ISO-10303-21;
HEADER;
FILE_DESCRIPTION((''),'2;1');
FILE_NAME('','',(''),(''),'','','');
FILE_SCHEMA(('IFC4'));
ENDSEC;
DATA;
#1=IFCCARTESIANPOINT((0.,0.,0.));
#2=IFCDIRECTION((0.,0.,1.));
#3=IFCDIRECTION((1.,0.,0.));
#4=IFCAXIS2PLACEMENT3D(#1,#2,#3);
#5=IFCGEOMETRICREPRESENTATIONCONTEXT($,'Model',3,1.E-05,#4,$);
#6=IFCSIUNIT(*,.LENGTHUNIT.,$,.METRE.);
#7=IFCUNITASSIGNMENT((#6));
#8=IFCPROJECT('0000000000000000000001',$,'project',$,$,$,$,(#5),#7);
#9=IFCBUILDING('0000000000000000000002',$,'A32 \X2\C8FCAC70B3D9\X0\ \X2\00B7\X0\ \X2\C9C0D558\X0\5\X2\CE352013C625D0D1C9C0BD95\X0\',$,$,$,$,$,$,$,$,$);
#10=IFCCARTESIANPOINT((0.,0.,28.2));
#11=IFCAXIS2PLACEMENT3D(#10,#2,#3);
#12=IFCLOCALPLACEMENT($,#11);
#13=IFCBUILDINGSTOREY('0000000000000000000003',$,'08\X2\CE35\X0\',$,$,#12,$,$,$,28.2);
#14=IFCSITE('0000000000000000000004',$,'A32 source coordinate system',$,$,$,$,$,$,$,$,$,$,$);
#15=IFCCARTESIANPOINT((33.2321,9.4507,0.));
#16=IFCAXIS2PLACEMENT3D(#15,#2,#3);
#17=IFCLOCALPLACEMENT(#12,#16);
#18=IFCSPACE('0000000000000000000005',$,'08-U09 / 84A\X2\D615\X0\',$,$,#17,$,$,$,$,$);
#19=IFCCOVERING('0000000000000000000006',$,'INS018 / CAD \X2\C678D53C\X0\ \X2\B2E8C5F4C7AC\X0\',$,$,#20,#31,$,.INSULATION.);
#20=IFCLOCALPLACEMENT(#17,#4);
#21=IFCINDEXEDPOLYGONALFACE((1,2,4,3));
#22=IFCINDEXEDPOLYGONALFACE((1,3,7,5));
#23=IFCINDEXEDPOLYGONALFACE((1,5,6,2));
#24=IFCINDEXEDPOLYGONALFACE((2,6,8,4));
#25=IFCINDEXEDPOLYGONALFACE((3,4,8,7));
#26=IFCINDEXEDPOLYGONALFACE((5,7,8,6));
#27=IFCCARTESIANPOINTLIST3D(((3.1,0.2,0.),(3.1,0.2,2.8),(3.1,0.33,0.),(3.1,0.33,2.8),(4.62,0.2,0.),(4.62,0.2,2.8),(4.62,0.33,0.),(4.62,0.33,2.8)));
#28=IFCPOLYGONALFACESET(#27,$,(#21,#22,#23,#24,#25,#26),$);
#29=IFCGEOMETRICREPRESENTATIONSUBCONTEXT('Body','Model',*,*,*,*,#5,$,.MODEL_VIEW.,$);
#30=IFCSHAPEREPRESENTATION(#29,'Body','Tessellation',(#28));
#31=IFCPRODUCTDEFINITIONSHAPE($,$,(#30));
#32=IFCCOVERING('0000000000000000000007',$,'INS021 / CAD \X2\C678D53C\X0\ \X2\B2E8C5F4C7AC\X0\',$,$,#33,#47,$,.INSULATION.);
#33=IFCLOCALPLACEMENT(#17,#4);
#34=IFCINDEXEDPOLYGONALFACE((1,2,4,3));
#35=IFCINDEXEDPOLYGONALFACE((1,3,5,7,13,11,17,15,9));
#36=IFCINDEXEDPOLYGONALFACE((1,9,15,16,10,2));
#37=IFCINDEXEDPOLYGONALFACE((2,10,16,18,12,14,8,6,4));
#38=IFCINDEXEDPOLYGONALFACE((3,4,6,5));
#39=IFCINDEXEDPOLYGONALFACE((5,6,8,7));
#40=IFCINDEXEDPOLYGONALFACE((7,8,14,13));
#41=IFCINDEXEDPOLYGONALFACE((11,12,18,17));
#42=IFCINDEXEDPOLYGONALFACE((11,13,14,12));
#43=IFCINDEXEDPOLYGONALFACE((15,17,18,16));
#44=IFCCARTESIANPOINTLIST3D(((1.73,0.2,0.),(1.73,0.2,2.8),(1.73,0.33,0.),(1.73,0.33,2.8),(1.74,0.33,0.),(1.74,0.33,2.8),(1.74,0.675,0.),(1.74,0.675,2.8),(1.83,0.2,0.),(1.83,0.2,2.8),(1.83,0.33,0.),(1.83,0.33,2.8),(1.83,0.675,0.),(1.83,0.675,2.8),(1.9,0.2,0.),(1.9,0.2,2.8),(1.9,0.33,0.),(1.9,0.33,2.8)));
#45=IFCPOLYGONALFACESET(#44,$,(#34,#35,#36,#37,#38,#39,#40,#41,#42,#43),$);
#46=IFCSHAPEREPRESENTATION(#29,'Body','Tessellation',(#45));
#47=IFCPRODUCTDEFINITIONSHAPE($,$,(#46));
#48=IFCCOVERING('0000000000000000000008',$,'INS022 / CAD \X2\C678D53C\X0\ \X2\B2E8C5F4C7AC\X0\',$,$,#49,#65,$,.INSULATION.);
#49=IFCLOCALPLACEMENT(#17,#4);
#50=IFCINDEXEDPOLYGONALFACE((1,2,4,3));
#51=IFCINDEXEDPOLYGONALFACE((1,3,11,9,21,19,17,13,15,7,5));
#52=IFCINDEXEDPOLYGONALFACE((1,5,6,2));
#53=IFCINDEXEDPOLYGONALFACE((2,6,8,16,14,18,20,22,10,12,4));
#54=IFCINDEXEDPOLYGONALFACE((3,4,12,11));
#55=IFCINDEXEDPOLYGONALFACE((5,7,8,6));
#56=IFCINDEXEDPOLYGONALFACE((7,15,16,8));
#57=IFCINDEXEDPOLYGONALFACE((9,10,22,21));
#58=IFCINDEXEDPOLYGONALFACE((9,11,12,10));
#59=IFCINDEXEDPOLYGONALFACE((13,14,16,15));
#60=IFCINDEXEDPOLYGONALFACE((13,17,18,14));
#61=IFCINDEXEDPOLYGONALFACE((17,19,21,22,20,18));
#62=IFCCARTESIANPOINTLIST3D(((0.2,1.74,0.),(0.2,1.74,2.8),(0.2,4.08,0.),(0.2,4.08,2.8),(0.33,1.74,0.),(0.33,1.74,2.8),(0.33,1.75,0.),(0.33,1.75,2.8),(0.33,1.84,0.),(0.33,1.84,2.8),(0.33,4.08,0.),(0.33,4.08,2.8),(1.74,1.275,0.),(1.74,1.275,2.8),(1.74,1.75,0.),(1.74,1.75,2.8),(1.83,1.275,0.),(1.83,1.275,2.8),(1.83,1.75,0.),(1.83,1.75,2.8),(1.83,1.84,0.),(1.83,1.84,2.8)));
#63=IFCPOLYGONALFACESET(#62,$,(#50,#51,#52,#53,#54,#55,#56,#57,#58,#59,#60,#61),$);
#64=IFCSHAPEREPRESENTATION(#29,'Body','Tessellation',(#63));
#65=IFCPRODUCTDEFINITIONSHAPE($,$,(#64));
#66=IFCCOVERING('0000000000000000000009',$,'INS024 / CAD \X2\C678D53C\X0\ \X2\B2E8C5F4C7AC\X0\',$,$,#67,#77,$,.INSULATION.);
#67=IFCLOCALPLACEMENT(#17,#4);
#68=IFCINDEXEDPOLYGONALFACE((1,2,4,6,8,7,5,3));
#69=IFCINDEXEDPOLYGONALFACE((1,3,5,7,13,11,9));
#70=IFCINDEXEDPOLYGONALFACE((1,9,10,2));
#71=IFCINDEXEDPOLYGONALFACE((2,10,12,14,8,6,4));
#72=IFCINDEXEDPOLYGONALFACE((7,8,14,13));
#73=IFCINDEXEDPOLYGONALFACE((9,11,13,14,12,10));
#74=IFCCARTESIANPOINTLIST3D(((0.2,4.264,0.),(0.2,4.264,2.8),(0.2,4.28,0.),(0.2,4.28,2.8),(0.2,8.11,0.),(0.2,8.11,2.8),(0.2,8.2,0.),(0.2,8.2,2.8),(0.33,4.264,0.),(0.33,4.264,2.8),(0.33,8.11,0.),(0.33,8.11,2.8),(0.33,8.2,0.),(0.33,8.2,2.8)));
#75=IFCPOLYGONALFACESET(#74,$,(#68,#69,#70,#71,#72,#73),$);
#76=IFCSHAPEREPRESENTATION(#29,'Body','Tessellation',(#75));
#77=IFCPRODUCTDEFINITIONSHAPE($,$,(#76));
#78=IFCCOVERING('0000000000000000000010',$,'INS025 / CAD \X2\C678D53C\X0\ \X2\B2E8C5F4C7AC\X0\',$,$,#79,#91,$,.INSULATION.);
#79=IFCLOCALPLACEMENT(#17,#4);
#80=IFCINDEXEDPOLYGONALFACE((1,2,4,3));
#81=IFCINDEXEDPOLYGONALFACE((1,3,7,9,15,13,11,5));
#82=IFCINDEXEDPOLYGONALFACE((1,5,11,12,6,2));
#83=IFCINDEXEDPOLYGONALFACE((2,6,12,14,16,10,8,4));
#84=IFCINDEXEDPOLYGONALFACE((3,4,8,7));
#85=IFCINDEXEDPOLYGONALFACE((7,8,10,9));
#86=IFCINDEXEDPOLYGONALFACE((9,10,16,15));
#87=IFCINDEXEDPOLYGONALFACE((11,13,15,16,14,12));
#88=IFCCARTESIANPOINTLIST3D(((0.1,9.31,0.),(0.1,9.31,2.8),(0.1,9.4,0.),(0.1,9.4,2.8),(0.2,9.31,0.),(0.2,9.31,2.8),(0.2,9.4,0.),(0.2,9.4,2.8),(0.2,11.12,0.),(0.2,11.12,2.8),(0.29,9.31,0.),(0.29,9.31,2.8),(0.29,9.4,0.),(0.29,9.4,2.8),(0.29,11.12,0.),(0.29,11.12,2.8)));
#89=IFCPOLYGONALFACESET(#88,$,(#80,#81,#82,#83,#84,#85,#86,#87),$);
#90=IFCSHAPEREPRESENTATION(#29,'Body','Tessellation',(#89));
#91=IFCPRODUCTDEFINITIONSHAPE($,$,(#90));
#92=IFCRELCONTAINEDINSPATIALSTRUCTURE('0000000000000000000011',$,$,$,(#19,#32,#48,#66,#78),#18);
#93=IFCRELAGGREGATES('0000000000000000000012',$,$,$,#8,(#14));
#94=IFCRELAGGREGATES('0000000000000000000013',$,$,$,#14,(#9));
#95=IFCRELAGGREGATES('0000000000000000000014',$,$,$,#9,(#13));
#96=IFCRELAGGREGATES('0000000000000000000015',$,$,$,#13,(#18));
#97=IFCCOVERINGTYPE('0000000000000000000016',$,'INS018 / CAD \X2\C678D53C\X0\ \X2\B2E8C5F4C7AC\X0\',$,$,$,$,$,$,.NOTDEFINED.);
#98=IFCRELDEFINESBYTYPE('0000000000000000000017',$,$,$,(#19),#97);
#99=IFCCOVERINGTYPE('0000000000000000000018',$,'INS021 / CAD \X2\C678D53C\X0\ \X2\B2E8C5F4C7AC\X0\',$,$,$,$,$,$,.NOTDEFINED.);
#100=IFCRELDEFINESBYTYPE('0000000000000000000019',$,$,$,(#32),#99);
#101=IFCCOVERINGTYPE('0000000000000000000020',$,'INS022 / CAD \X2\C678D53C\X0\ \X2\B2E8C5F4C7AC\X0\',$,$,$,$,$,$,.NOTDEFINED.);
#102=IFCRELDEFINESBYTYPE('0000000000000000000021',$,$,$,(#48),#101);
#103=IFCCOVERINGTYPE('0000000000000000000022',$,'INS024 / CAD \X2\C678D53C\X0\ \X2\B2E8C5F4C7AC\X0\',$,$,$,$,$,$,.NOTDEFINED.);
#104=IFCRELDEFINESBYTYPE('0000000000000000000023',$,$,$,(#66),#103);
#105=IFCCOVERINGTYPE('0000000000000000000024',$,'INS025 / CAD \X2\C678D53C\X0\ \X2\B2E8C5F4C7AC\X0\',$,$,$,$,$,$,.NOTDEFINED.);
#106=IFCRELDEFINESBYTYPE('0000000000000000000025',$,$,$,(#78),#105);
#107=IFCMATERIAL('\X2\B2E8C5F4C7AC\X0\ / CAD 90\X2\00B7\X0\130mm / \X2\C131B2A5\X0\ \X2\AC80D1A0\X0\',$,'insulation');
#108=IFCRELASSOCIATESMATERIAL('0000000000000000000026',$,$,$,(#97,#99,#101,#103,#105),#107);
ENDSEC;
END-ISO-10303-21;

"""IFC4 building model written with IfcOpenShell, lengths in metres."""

from ifc_helpers import new_model, si_unit, frame, origin, origin_with_axes, place, context, subcontext, project, spatial, polyline, outline, extrude, source, transform, mapped, material, type_object, type_shapes, element, save


model = new_model("IFC4")

# Units and contexts
model_context = context("Model", 3, precision=1e-05, world=origin_with_axes())
body_context = subcontext(model_context, "Body", "Model", "MODEL_VIEW")
ifc_project = project(units=[si_unit("LENGTHUNIT", "METRE")], contexts=[model_context])

# Site, building, storey, space
storey_placement = place(None, frame((0.0, 0.0, 28.2), z_axis=(0.0, 0.0, 1.0), x_axis=(1.0, 0.0, 0.0)))
space_placement = place(storey_placement, frame((33.2321, 9.4507, 0.0), z_axis=(0.0, 0.0, 1.0), x_axis=(1.0, 0.0, 0.0)))
site = spatial("IfcSite", under=ifc_project, Name="A32 source coordinate system")
building = spatial("IfcBuilding", under=site, Name="A32 주거동 · 지하5층–옥탑지붕")
storey = spatial("IfcBuildingStorey", under=building, at=storey_placement, Name="08층", Elevation=28.2)
space = spatial("IfcSpace", under=storey, at=space_placement, Name="08-U09 / 84A형")

# Coverings
ifc_material = material(Name="단열재 / CAD 90·130mm / 성능 검토", Category="insulation")
covering_type_1 = type_object("IfcCoveringType", Name="INS018 / CAD 외피 단열재", PredefinedType="NOTDEFINED", material=ifc_material)
shared_shape_1 = source(origin(), body_context, "Body", "SweptSolid", [
    extrude(outline(polyline([(3.1, 0.33), (4.62, 0.33), (4.62, 0.2), (3.1, 0.2), (3.1, 0.33)])), origin(), (0.0, 0.0, 1.0), 2.8),
])
type_shapes(covering_type_1, [shared_shape_1])
covering_1_placement = place(space_placement, origin_with_axes())
element("IfcCovering", 1, at=covering_1_placement, inside=space, type_object=covering_type_1, Name="INS018 / CAD 외피 단열재", PredefinedType="INSULATION", context=body_context, shape_type="MappedRepresentation", body=[
    mapped(shared_shape_1, transform((0.0, 0.0, 0.0), scale=1.0)),
])
covering_type_2 = type_object("IfcCoveringType", Name="INS021 / CAD 외피 단열재", PredefinedType="NOTDEFINED", material=ifc_material)
shared_shape_2 = source(origin(), body_context, "Body", "SweptSolid", [
    extrude(outline(polyline([(1.83, 0.33), (1.9, 0.33), (1.9, 0.2), (1.83, 0.2), (1.73, 0.2), (1.73, 0.33), (1.74, 0.33), (1.74, 0.675), (1.83, 0.675), (1.83, 0.33)])), origin(), (0.0, 0.0, 1.0), 2.8),
])
type_shapes(covering_type_2, [shared_shape_2])
covering_2_placement = place(space_placement, origin_with_axes())
element("IfcCovering", 2, at=covering_2_placement, inside=space, type_object=covering_type_2, Name="INS021 / CAD 외피 단열재", PredefinedType="INSULATION", context=body_context, shape_type="MappedRepresentation", body=[
    mapped(shared_shape_2, transform((0.0, 0.0, 0.0), scale=1.0)),
])
covering_type_3 = type_object("IfcCoveringType", Name="INS022 / CAD 외피 단열재", PredefinedType="NOTDEFINED", material=ifc_material)
shared_shape_3 = source(origin(), body_context, "Body", "SweptSolid", [
    extrude(outline(polyline([(1.83, 1.84), (1.83, 1.75), (1.83, 1.275), (1.74, 1.275), (1.74, 1.75), (0.33, 1.75), (0.33, 1.74), (0.2, 1.74), (0.2, 4.08), (0.33, 4.08), (0.33, 1.84), (1.83, 1.84)])), origin(), (0.0, 0.0, 1.0), 2.8),
])
type_shapes(covering_type_3, [shared_shape_3])
covering_3_placement = place(space_placement, origin_with_axes())
element("IfcCovering", 3, at=covering_3_placement, inside=space, type_object=covering_type_3, Name="INS022 / CAD 외피 단열재", PredefinedType="INSULATION", context=body_context, shape_type="MappedRepresentation", body=[
    mapped(shared_shape_3, transform((0.0, 0.0, 0.0), scale=1.0)),
])
covering_type_4 = type_object("IfcCoveringType", Name="INS024 / CAD 외피 단열재", PredefinedType="NOTDEFINED", material=ifc_material)
shared_shape_4 = source(origin(), body_context, "Body", "SweptSolid", [
    extrude(outline(polyline([(0.2, 8.11), (0.2, 8.2), (0.33, 8.2), (0.33, 8.11), (0.33, 4.264), (0.2, 4.264), (0.2, 4.28), (0.2, 8.11)])), origin(), (0.0, 0.0, 1.0), 2.8),
])
type_shapes(covering_type_4, [shared_shape_4])
covering_4_placement = place(space_placement, origin_with_axes())
element("IfcCovering", 4, at=covering_4_placement, inside=space, type_object=covering_type_4, Name="INS024 / CAD 외피 단열재", PredefinedType="INSULATION", context=body_context, shape_type="MappedRepresentation", body=[
    mapped(shared_shape_4, transform((0.0, 0.0, 0.0), scale=1.0)),
])
covering_type_5 = type_object("IfcCoveringType", Name="INS025 / CAD 외피 단열재", PredefinedType="NOTDEFINED", material=ifc_material)
shared_shape_5 = source(origin(), body_context, "Body", "SweptSolid", [
    extrude(outline(polyline([(0.2, 9.4), (0.2, 11.12), (0.29, 11.12), (0.29, 9.4), (0.29, 9.31), (0.2, 9.31), (0.1, 9.31), (0.1, 9.4), (0.2, 9.4)])), origin(), (0.0, 0.0, 1.0), 2.8),
])
type_shapes(covering_type_5, [shared_shape_5])
covering_5_placement = place(space_placement, origin_with_axes())
element("IfcCovering", 5, at=covering_5_placement, inside=space, type_object=covering_type_5, Name="INS025 / CAD 외피 단열재", PredefinedType="INSULATION", context=body_context, shape_type="MappedRepresentation", body=[
    mapped(shared_shape_5, transform((0.0, 0.0, 0.0), scale=1.0)),
])

save(model, "model.ifc")
